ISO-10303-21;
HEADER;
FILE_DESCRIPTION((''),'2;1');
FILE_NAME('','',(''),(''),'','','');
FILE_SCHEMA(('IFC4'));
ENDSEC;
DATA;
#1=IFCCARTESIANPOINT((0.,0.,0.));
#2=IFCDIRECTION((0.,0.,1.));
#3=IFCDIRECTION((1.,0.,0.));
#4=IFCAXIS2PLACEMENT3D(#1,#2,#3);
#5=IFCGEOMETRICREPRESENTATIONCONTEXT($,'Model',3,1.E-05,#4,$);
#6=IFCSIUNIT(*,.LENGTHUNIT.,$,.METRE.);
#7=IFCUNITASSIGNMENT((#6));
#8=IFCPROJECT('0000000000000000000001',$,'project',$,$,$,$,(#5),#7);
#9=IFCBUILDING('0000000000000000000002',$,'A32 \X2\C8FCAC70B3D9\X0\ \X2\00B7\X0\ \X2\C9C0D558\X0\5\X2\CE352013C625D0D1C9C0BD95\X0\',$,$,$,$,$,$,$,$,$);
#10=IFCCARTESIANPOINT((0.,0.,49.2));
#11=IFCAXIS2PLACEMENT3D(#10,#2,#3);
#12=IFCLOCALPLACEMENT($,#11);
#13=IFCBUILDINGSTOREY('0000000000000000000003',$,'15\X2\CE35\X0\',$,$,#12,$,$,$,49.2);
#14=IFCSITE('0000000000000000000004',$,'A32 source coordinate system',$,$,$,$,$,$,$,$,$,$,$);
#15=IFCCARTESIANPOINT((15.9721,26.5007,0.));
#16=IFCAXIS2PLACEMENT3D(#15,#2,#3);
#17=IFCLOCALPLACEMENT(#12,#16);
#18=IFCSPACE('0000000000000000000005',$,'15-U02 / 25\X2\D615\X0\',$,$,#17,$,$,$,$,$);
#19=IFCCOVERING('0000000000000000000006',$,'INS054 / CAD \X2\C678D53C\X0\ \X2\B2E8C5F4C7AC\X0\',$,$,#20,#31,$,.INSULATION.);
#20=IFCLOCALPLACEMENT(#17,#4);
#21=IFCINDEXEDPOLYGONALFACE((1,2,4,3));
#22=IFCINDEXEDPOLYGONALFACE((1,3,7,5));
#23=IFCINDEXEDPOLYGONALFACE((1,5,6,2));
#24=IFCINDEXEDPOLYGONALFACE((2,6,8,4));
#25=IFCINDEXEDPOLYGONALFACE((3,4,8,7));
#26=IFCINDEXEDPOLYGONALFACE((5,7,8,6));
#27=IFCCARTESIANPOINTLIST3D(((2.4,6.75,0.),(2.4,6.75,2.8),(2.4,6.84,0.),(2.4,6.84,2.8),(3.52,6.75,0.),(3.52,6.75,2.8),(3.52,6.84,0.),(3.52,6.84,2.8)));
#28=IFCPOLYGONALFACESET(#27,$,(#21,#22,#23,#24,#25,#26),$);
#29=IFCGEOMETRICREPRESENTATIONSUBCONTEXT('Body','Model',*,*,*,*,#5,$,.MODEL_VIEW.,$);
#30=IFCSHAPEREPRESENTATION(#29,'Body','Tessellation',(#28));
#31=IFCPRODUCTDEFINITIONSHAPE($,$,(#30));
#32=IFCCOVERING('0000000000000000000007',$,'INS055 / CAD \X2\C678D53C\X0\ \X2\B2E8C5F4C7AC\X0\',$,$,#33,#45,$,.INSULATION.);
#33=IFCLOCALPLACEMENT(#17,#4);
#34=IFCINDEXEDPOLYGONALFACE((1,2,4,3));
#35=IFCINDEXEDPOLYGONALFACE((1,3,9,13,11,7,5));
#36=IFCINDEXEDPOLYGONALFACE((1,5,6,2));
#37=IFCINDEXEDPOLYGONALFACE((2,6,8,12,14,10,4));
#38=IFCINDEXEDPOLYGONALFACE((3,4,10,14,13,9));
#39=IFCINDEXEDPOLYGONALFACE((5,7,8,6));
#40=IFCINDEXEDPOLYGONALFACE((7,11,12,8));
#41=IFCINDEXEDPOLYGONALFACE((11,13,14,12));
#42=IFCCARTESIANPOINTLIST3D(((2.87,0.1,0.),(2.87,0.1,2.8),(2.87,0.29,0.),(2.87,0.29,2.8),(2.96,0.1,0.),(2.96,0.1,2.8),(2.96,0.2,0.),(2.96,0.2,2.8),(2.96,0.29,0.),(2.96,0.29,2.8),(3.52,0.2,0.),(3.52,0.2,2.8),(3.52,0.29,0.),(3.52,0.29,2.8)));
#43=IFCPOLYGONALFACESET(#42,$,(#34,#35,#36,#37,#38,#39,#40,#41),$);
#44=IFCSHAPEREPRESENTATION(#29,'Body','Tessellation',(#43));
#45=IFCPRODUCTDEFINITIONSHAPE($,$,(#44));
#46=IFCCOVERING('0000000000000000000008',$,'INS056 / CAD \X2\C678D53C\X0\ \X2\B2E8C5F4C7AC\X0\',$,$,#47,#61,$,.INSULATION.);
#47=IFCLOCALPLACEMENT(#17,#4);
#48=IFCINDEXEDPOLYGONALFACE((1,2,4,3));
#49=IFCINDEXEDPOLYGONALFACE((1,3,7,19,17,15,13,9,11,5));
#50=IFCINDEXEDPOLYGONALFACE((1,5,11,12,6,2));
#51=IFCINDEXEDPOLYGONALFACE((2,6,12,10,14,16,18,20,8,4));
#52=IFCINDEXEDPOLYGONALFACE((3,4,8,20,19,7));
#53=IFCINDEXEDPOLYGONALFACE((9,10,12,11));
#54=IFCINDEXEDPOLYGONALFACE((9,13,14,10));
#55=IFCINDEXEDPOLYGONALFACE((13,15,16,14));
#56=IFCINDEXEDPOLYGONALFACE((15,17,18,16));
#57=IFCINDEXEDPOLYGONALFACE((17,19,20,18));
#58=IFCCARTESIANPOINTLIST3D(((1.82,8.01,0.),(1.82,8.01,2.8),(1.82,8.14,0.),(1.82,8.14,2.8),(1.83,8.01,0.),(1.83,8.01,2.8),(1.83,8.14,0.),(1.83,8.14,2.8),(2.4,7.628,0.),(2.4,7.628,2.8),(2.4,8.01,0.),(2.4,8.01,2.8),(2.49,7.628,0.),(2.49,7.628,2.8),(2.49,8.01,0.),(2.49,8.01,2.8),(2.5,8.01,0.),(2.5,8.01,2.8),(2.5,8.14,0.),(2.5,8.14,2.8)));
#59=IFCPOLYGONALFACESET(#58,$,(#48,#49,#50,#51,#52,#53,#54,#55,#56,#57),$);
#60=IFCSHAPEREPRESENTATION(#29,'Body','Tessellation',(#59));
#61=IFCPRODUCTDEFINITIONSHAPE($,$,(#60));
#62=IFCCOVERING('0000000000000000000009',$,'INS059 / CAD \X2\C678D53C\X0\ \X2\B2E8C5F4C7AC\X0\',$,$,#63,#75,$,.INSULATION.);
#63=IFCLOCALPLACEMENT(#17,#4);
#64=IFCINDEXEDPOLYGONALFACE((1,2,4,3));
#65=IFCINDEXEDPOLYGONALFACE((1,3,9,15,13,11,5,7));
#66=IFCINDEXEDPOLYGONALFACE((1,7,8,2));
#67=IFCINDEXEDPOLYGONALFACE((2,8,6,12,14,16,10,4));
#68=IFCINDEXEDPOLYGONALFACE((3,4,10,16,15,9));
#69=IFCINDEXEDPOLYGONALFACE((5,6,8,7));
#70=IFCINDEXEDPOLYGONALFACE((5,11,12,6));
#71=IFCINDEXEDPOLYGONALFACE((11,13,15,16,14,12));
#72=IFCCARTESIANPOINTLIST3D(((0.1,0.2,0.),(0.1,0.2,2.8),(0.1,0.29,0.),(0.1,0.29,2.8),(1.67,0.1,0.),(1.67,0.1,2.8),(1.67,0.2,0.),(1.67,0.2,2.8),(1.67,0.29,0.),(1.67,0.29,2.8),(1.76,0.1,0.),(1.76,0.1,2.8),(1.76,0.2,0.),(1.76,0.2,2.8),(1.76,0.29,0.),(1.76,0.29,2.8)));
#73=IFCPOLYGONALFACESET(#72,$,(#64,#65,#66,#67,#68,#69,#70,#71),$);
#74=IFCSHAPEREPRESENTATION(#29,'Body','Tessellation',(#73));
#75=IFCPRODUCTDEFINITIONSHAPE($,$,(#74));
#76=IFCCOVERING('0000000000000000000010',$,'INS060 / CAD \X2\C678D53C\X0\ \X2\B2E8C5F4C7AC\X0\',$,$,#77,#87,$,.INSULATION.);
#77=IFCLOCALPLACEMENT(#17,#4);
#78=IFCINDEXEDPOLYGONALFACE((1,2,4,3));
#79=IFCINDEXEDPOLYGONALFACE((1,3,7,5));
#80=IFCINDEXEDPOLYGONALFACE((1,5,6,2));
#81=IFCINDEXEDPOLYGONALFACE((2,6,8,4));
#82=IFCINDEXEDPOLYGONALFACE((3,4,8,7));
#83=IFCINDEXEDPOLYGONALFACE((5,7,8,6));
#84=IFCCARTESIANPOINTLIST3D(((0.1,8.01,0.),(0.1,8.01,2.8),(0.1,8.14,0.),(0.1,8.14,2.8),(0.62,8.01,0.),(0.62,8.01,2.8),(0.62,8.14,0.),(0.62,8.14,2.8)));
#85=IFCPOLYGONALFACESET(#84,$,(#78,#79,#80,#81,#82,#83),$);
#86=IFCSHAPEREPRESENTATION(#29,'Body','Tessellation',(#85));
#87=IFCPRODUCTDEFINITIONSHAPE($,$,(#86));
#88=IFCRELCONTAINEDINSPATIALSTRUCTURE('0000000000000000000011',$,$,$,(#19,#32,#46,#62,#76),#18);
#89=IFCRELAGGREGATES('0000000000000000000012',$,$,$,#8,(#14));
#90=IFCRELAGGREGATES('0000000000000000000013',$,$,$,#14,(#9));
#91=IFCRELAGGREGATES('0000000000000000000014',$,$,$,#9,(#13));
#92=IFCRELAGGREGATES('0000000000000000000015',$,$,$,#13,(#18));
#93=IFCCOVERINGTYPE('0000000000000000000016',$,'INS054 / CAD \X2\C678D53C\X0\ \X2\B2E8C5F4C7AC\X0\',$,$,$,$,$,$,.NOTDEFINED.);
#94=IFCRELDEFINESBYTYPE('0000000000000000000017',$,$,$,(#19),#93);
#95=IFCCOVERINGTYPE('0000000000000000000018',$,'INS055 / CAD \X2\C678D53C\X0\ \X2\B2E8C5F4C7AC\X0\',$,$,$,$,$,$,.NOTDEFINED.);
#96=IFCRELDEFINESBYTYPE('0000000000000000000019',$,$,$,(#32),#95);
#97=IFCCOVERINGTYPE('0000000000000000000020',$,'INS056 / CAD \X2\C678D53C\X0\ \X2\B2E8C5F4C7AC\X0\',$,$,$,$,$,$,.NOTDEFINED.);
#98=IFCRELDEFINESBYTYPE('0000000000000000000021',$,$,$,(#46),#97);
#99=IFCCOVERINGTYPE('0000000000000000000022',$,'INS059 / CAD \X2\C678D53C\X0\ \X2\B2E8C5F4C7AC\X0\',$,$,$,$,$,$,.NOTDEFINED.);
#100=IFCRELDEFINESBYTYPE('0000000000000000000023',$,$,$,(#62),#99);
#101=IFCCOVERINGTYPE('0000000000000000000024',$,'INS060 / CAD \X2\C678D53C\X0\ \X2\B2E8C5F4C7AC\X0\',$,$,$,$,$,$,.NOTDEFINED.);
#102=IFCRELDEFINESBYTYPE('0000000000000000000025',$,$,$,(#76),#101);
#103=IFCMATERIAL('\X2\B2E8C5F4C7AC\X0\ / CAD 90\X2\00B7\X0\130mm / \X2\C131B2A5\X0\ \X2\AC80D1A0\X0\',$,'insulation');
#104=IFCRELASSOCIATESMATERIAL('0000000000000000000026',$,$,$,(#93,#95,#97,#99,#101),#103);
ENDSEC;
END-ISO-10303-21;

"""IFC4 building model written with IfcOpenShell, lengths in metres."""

from ifc_helpers import new_model, si_unit, frame, origin, origin_with_axes, place, context, subcontext, project, spatial, polyline, outline, extrude, source, transform, mapped, material, type_object, type_shapes, element, save


model = new_model("IFC4")

# Units and contexts
model_context = context("Model", 3, precision=1e-05, world=origin_with_axes())
body_context = subcontext(model_context, "Body", "Model", "MODEL_VIEW")
ifc_project = project(units=[si_unit("LENGTHUNIT", "METRE")], contexts=[model_context])

# Site, building, storey, space
storey_placement = place(None, frame((0.0, 0.0, 49.2), z_axis=(0.0, 0.0, 1.0), x_axis=(1.0, 0.0, 0.0)))
space_placement = place(storey_placement, frame((15.9721, 26.5007, 0.0), z_axis=(0.0, 0.0, 1.0), x_axis=(1.0, 0.0, 0.0)))
site = spatial("IfcSite", under=ifc_project, Name="A32 source coordinate system")
building = spatial("IfcBuilding", under=site, Name="A32 주거동 · 지하5층–옥탑지붕")
storey = spatial("IfcBuildingStorey", under=building, at=storey_placement, Name="15층", Elevation=49.2)
space = spatial("IfcSpace", under=storey, at=space_placement, Name="15-U02 / 25형")

# Coverings
ifc_material = material(Name="단열재 / CAD 90·130mm / 성능 검토", Category="insulation")
covering_type_1 = type_object("IfcCoveringType", Name="INS054 / CAD 외피 단열재", PredefinedType="NOTDEFINED", material=ifc_material)
shared_shape_1 = source(origin(), body_context, "Body", "SweptSolid", [
    extrude(outline(polyline([(2.4, 6.84), (3.52, 6.84), (3.52, 6.75), (2.4, 6.75), (2.4, 6.84)])), origin(), (0.0, 0.0, 1.0), 2.8),
])
type_shapes(covering_type_1, [shared_shape_1])
covering_1_placement = place(space_placement, origin_with_axes())
element("IfcCovering", 1, at=covering_1_placement, inside=space, type_object=covering_type_1, Name="INS054 / CAD 외피 단열재", PredefinedType="INSULATION", context=body_context, shape_type="MappedRepresentation", body=[
    mapped(shared_shape_1, transform((0.0, 0.0, 0.0), scale=1.0)),
])
covering_type_2 = type_object("IfcCoveringType", Name="INS055 / CAD 외피 단열재", PredefinedType="NOTDEFINED", material=ifc_material)
shared_shape_2 = source(origin(), body_context, "Body", "SweptSolid", [
    extrude(outline(polyline([(2.87, 0.29), (2.96, 0.29), (3.52, 0.29), (3.52, 0.2), (2.96, 0.2), (2.96, 0.1), (2.87, 0.1), (2.87, 0.29)])), origin(), (0.0, 0.0, 1.0), 2.8),
])
type_shapes(covering_type_2, [shared_shape_2])
covering_2_placement = place(space_placement, origin_with_axes())
element("IfcCovering", 2, at=covering_2_placement, inside=space, type_object=covering_type_2, Name="INS055 / CAD 외피 단열재", PredefinedType="INSULATION", context=body_context, shape_type="MappedRepresentation", body=[
    mapped(shared_shape_2, transform((0.0, 0.0, 0.0), scale=1.0)),
])
covering_type_3 = type_object("IfcCoveringType", Name="INS056 / CAD 외피 단열재", PredefinedType="NOTDEFINED", material=ifc_material)
shared_shape_3 = source(origin(), body_context, "Body", "SweptSolid", [
    extrude(outline(polyline([(2.49, 7.628), (2.4, 7.628), (2.4, 8.01), (1.83, 8.01), (1.82, 8.01), (1.82, 8.14), (1.83, 8.14), (2.5, 8.14), (2.5, 8.01), (2.49, 8.01), (2.49, 7.628)])), origin(), (0.0, 0.0, 1.0), 2.8),
])
type_shapes(covering_type_3, [shared_shape_3])
covering_3_placement = place(space_placement, origin_with_axes())
element("IfcCovering", 3, at=covering_3_placement, inside=space, type_object=covering_type_3, Name="INS056 / CAD 외피 단열재", PredefinedType="INSULATION", context=body_context, shape_type="MappedRepresentation", body=[
    mapped(shared_shape_3, transform((0.0, 0.0, 0.0), scale=1.0)),
])
covering_type_4 = type_object("IfcCoveringType", Name="INS059 / CAD 외피 단열재", PredefinedType="NOTDEFINED", material=ifc_material)
shared_shape_4 = source(origin(), body_context, "Body", "SweptSolid", [
    extrude(outline(polyline([(1.76, 0.1), (1.67, 0.1), (1.67, 0.2), (0.1, 0.2), (0.1, 0.29), (1.67, 0.29), (1.76, 0.29), (1.76, 0.2), (1.76, 0.1)])), origin(), (0.0, 0.0, 1.0), 2.8),
])
type_shapes(covering_type_4, [shared_shape_4])
covering_4_placement = place(space_placement, origin_with_axes())
element("IfcCovering", 4, at=covering_4_placement, inside=space, type_object=covering_type_4, Name="INS059 / CAD 외피 단열재", PredefinedType="INSULATION", context=body_context, shape_type="MappedRepresentation", body=[
    mapped(shared_shape_4, transform((0.0, 0.0, 0.0), scale=1.0)),
])
covering_type_5 = type_object("IfcCoveringType", Name="INS060 / CAD 외피 단열재", PredefinedType="NOTDEFINED", material=ifc_material)
shared_shape_5 = source(origin(), body_context, "Body", "SweptSolid", [
    extrude(outline(polyline([(0.1, 8.01), (0.1, 8.14), (0.62, 8.14), (0.62, 8.01), (0.1, 8.01)])), origin(), (0.0, 0.0, 1.0), 2.8),
])
type_shapes(covering_type_5, [shared_shape_5])
covering_5_placement = place(space_placement, origin_with_axes())
element("IfcCovering", 5, at=covering_5_placement, inside=space, type_object=covering_type_5, Name="INS060 / CAD 외피 단열재", PredefinedType="INSULATION", context=body_context, shape_type="MappedRepresentation", body=[
    mapped(shared_shape_5, transform((0.0, 0.0, 0.0), scale=1.0)),
])

save(model, "model.ifc")
